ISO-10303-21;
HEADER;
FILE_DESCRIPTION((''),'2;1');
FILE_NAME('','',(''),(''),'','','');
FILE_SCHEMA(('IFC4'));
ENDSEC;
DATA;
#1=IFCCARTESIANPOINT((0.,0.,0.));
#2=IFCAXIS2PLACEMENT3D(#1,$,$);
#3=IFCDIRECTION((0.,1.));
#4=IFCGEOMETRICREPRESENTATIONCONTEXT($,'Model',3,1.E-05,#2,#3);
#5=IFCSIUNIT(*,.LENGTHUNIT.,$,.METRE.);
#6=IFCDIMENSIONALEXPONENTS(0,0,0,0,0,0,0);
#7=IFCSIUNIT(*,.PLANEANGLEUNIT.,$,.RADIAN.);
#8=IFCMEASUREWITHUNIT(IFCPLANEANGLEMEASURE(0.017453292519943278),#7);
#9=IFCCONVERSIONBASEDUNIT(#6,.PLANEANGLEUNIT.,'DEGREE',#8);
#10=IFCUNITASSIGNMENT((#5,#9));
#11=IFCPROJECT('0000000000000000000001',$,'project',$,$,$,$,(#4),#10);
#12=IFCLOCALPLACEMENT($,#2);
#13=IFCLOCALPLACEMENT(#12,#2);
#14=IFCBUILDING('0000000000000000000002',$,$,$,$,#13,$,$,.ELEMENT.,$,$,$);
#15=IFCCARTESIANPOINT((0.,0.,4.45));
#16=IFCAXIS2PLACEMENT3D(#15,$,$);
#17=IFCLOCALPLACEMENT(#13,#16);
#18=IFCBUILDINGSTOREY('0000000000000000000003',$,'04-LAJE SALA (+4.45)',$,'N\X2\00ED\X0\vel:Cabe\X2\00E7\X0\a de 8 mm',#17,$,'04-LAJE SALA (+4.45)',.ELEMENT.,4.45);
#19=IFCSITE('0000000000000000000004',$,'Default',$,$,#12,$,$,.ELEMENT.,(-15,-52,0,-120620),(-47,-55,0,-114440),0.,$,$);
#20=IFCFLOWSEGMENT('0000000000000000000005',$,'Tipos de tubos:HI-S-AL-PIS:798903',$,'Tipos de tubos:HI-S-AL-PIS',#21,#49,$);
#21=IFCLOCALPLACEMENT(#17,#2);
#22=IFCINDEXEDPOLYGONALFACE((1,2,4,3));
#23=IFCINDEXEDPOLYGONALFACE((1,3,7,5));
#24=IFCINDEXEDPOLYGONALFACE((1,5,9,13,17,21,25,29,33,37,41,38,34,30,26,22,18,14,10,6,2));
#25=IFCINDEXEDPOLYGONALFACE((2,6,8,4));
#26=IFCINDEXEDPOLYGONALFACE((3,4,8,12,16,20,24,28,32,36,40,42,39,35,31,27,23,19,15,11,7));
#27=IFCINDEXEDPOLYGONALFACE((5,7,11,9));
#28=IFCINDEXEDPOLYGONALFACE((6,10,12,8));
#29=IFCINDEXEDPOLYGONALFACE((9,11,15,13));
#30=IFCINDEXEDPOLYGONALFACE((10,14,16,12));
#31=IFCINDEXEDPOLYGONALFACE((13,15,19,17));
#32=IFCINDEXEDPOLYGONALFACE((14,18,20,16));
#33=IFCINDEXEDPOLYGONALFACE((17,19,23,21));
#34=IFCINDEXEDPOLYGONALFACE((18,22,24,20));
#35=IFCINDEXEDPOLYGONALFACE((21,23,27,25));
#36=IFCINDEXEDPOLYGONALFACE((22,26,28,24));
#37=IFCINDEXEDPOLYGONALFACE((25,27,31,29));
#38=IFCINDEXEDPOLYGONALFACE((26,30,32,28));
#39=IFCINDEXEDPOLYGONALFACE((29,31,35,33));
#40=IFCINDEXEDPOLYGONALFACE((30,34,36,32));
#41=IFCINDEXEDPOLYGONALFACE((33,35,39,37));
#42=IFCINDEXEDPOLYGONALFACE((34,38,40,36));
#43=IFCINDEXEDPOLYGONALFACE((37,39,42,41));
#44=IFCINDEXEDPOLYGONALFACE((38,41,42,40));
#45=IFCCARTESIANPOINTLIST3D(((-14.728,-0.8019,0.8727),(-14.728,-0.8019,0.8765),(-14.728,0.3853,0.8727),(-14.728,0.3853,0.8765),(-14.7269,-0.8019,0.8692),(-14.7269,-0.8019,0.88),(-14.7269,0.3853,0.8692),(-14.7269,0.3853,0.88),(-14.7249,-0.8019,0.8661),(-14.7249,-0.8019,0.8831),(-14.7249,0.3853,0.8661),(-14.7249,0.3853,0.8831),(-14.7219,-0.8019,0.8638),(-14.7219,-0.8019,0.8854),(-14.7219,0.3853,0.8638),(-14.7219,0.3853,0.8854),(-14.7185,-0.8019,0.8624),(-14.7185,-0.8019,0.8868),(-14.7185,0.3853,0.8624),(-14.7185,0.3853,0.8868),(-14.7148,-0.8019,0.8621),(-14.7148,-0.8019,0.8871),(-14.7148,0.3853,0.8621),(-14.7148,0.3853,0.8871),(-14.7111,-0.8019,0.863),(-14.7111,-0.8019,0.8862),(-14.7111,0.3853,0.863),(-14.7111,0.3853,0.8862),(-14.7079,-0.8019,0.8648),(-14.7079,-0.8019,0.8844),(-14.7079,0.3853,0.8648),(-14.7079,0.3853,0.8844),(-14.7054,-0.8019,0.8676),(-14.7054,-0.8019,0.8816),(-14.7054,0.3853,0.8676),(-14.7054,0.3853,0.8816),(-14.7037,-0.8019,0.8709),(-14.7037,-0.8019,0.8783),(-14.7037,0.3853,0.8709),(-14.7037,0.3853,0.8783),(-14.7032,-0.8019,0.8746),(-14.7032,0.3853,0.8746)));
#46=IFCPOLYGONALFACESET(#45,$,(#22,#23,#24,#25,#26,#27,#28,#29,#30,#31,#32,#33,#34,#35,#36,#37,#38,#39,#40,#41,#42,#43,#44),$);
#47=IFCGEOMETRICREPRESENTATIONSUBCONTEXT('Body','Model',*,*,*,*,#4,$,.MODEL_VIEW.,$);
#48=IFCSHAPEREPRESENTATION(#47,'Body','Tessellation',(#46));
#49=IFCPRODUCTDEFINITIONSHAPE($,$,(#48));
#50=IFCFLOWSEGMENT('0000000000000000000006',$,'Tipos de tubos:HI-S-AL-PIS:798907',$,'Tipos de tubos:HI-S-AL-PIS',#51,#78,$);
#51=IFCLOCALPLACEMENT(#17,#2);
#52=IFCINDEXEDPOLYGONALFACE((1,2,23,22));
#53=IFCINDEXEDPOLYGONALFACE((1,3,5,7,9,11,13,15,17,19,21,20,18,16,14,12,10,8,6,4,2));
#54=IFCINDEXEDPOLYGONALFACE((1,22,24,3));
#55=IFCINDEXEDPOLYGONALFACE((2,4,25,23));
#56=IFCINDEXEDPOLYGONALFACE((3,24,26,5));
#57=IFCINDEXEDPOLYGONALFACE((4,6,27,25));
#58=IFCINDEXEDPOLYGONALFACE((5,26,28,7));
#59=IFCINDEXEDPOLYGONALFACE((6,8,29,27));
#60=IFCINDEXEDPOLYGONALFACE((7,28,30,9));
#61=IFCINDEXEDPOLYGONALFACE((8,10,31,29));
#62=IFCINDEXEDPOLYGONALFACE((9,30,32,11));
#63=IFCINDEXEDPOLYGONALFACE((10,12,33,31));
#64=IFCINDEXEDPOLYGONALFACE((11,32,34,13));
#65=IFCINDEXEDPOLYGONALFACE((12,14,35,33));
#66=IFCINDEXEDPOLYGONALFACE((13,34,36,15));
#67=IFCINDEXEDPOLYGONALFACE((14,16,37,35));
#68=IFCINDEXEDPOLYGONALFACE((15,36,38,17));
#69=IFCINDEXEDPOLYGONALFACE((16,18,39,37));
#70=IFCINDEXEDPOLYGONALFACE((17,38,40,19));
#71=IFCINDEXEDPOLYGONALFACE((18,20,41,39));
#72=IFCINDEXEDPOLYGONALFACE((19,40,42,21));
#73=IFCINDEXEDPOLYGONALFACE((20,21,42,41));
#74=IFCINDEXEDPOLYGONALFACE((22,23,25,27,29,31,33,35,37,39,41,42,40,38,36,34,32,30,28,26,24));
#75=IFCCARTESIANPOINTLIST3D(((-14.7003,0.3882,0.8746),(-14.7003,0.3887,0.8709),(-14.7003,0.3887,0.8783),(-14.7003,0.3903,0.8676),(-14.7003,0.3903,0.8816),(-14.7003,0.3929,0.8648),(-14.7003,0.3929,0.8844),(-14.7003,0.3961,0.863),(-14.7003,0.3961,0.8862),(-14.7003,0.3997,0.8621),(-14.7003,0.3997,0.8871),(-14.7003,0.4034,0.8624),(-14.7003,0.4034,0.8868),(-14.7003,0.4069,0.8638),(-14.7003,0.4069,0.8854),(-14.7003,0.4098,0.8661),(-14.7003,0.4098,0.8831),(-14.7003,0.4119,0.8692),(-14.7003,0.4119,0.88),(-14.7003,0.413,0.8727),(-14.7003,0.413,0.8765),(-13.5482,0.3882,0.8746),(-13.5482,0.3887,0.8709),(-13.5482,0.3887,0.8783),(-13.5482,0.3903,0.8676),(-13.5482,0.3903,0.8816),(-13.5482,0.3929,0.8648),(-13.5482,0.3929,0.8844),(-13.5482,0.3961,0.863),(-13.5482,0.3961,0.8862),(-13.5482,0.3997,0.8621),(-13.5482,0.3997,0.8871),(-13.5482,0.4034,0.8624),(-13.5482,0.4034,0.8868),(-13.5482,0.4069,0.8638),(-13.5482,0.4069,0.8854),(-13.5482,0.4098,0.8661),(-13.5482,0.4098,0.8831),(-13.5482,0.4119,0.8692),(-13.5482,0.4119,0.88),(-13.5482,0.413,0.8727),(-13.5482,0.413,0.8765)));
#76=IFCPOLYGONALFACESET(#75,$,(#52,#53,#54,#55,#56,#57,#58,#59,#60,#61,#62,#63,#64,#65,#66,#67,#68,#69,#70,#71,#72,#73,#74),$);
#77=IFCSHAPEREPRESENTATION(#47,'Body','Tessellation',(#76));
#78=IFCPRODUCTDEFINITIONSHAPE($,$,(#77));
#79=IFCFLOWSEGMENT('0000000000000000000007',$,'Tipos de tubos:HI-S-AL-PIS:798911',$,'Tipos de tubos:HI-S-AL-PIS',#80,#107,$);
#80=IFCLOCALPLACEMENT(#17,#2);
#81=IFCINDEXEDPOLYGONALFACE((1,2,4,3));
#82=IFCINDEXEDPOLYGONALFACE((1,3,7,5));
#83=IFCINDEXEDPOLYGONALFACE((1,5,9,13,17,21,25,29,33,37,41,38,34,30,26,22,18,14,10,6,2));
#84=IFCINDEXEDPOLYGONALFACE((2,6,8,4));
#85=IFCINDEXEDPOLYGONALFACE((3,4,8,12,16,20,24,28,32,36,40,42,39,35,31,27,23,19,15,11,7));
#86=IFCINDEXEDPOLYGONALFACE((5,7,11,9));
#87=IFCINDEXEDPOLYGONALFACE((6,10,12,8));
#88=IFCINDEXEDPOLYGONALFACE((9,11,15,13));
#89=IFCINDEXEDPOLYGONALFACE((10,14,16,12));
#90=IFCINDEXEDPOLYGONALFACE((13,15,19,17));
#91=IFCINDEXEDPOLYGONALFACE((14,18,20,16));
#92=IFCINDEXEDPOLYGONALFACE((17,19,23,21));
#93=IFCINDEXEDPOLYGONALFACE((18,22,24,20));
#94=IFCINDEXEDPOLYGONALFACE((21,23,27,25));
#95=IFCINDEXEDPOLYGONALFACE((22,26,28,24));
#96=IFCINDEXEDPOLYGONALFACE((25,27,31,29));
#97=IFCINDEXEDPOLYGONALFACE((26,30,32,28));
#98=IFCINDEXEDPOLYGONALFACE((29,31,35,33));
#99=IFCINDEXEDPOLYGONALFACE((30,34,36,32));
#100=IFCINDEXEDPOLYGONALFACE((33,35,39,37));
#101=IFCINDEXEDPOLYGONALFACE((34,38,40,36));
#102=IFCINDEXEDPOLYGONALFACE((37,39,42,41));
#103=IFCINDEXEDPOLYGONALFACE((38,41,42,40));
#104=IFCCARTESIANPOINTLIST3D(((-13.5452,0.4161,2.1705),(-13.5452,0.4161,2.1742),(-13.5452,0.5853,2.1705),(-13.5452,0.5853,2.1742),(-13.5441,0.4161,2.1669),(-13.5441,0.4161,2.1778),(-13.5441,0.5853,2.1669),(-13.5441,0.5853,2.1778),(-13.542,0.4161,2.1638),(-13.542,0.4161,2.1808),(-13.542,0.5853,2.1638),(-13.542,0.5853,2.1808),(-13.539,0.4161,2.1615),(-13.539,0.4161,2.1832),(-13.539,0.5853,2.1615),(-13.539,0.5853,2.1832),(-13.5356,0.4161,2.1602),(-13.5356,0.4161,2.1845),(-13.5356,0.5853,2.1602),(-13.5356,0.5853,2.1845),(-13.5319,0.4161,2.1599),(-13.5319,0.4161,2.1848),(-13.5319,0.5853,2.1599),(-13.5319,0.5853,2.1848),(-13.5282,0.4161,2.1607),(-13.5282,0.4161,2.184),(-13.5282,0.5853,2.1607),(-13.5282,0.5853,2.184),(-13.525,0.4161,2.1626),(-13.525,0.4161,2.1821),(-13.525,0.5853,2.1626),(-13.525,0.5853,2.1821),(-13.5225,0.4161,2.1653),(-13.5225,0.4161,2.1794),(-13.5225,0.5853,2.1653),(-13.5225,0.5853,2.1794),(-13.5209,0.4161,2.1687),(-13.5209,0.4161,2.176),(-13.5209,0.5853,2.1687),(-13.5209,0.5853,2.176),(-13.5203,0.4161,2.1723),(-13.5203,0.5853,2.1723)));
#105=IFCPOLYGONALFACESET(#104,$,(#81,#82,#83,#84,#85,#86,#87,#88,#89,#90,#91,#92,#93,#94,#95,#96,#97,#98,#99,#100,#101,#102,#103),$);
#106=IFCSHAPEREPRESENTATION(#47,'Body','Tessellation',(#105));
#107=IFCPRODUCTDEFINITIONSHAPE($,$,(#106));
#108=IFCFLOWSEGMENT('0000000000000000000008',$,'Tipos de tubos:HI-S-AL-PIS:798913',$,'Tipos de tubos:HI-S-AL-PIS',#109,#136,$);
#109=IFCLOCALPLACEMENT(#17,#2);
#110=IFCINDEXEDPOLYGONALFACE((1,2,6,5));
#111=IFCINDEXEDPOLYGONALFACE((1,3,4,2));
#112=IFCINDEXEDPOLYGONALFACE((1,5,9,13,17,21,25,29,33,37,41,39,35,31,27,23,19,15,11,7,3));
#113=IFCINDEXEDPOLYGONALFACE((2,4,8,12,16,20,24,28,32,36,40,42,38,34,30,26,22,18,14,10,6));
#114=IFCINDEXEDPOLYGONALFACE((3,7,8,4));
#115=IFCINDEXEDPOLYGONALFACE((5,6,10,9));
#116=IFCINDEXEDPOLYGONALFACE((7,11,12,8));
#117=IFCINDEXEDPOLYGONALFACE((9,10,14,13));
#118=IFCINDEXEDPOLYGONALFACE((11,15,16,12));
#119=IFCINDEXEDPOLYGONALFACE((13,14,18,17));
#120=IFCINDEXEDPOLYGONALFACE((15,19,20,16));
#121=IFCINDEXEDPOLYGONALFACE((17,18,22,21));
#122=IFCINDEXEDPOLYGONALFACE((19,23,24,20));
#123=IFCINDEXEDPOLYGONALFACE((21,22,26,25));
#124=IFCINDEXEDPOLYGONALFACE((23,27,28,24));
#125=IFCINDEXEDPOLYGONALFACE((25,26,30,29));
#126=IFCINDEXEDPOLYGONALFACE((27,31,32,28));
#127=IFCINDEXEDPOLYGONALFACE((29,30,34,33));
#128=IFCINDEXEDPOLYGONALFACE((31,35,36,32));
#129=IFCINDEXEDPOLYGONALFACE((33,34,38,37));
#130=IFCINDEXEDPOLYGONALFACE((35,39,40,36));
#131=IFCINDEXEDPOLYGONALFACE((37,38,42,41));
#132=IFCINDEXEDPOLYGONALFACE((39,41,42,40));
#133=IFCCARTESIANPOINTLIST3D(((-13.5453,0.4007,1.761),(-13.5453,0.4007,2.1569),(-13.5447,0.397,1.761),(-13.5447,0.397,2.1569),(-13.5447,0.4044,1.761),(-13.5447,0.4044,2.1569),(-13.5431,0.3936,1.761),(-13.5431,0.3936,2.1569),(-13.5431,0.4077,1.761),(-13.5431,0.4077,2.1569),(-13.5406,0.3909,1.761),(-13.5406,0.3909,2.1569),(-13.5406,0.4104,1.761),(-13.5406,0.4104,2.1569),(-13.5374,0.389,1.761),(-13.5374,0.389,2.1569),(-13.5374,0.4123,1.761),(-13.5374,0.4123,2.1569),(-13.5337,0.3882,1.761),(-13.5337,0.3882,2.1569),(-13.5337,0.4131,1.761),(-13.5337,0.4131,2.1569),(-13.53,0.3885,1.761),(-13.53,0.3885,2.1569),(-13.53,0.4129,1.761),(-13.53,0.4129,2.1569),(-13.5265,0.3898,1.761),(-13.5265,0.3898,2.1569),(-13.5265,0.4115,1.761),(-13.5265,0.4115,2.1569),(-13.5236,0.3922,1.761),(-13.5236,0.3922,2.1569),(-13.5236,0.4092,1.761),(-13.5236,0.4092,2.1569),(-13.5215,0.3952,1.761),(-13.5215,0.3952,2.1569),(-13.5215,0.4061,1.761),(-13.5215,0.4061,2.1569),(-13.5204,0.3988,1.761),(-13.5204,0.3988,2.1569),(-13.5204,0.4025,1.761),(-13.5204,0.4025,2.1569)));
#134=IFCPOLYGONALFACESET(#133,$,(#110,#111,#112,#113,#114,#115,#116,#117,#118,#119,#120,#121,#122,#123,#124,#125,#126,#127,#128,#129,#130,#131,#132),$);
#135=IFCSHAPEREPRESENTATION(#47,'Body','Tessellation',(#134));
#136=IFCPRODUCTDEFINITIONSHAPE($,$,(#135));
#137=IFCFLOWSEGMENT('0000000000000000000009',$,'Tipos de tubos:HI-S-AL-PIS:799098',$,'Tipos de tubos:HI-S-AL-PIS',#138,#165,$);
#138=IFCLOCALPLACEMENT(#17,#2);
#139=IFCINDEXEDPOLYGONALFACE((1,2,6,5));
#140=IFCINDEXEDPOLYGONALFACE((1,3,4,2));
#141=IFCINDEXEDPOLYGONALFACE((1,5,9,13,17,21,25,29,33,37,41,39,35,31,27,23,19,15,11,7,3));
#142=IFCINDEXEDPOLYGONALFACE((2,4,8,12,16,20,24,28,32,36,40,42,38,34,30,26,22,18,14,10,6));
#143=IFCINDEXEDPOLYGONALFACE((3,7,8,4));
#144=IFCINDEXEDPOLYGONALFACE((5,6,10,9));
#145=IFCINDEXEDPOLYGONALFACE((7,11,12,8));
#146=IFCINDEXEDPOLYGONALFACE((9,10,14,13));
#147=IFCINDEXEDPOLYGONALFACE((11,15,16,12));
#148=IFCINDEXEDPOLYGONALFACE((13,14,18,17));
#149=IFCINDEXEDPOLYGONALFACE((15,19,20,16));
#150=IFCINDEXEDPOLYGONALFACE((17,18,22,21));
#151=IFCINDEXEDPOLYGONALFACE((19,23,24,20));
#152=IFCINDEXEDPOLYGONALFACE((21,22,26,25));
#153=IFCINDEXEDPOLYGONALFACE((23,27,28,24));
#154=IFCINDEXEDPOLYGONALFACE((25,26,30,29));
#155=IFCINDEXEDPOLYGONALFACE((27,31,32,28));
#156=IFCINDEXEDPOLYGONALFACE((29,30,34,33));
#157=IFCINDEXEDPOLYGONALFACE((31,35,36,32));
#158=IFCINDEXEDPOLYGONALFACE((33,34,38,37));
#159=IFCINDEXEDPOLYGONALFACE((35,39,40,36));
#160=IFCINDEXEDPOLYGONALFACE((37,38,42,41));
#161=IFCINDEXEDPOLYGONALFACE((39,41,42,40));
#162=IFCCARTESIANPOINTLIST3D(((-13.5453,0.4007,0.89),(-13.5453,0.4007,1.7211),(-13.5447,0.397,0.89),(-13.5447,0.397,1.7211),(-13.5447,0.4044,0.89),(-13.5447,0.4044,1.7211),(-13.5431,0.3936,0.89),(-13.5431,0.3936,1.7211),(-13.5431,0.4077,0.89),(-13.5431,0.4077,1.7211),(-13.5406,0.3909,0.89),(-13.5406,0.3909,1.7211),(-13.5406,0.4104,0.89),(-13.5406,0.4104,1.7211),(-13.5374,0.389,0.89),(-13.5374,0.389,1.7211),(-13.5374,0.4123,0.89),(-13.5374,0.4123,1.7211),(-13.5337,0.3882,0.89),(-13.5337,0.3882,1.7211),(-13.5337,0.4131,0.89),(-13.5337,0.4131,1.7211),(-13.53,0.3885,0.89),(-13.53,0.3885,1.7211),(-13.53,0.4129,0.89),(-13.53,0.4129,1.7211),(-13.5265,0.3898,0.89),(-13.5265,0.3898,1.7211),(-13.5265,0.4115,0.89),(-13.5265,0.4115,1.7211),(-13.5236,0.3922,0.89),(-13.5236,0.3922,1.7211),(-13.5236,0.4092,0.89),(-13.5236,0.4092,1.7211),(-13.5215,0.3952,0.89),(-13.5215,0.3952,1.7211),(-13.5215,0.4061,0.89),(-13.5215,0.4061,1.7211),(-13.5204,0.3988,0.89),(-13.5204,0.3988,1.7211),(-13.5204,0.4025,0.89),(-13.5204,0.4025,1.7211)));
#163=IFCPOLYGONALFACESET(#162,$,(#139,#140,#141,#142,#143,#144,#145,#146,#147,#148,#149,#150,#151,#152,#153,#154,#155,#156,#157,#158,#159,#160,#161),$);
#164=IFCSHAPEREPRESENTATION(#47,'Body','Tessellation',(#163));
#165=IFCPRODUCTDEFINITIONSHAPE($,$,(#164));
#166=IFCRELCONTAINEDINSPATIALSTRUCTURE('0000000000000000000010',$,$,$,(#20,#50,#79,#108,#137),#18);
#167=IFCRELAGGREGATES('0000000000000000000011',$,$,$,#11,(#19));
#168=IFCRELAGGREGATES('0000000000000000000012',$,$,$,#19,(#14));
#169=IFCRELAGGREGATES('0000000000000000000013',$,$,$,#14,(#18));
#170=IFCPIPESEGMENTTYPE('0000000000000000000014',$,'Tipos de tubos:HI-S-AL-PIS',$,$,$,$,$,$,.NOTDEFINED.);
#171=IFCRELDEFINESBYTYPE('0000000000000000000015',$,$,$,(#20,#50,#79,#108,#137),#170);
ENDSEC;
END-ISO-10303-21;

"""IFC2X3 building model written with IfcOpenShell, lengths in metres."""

from ifc_helpers import new_model, entity, si_unit, converted_unit, direction, frame, frame_2d, origin, origin_2d_with_axis, place, context, subcontext, project, spatial, circle, extrude, type_object, element, save


model = new_model("IFC2X3")

# Units and contexts
model_context = context("Model", 3, precision=1e-05, world=origin(), true_north=direction((0.0, 1.0)))
body_context = subcontext(model_context, "Body", "Model", "MODEL_VIEW")
ifc_project = project(units=[si_unit("LENGTHUNIT", "METRE"), converted_unit("PLANEANGLEUNIT", "DEGREE", entity("IfcPlaneAngleMeasure", 0.017453292519943278), si_unit("PLANEANGLEUNIT", "RADIAN"), dimensions=[0, 0, 0, 0, 0, 0, 0])], contexts=[model_context])

# Site, building, storey
site_placement = place(None, origin())
site = spatial("IfcSite", under=ifc_project, at=site_placement, Name="Default", CompositionType="ELEMENT", RefLatitude=(-15, -52, 0, -120620), RefLongitude=(-47, -55, 0, -114440), RefElevation=0.0)
building_placement = place(site_placement, origin())
building = spatial("IfcBuilding", under=site, at=building_placement, CompositionType="ELEMENT")
storey_placement = place(building_placement, frame((0.0, 0.0, 4.45)))
storey = spatial("IfcBuildingStorey", under=building, at=storey_placement, Name="04-LAJE SALA (+4.45)", ObjectType="Nível:Cabeça de 8 mm", LongName="04-LAJE SALA (+4.45)", CompositionType="ELEMENT", Elevation=4.45)

# Flow segments
pipe_segment_type_1 = type_object("IfcPipeSegmentType", Name="Tipos de tubos:HI-S-AL-PIS", PredefinedType="NOTDEFINED")
flow_segment_1_placement = place(storey_placement, origin())
element("IfcFlowSegment", 1, at=flow_segment_1_placement, inside=storey, type_object=pipe_segment_type_1, Name="Tipos de tubos:HI-S-AL-PIS:798903", ObjectType="Tipos de tubos:HI-S-AL-PIS", context=body_context, shape_type="SweptSolid", body=[
    extrude(circle(Radius=0.0125, at=origin_2d_with_axis()), frame((-14.7157, -0.8019, 0.8746), z_axis=(0.0, 1.0, 0.0), x_axis=(1.0, 0.0, 0.0)), (0.0, 0.0, 1.0), 1.1872),
])
flow_segment_2_placement = place(storey_placement, origin())
element("IfcFlowSegment", 2, at=flow_segment_2_placement, inside=storey, type_object=pipe_segment_type_1, Name="Tipos de tubos:HI-S-AL-PIS:798907", ObjectType="Tipos de tubos:HI-S-AL-PIS", context=body_context, shape_type="SweptSolid", body=[
    extrude(circle(Radius=0.0125, at=frame_2d((0.0, 0.0), x_axis=(1.0, 0.0))), frame((-14.7003, 0.4007, 0.8746), z_axis=(1.0, 0.0, 0.0), x_axis=(0.0, -1.0, 0.0)), (0.0, 0.0, 1.0), 1.1521),
])
flow_segment_3_placement = place(storey_placement, origin())
element("IfcFlowSegment", 3, at=flow_segment_3_placement, inside=storey, type_object=pipe_segment_type_1, Name="Tipos de tubos:HI-S-AL-PIS:798911", ObjectType="Tipos de tubos:HI-S-AL-PIS", context=body_context, shape_type="SweptSolid", body=[
    extrude(circle(Radius=0.0125, at=origin_2d_with_axis()), frame((-13.5328, 0.4161, 2.1723), z_axis=(0.0, 1.0, 0.0), x_axis=(1.0, 0.0, 0.0)), (0.0, 0.0, 1.0), 0.1692),
])
flow_segment_4_placement = place(storey_placement, origin())
element("IfcFlowSegment", 4, at=flow_segment_4_placement, inside=storey, type_object=pipe_segment_type_1, Name="Tipos de tubos:HI-S-AL-PIS:798913", ObjectType="Tipos de tubos:HI-S-AL-PIS", context=body_context, shape_type="SweptSolid", body=[
    extrude(circle(Radius=0.0125, at=origin_2d_with_axis()), frame((-13.5328, 0.4007, 1.761), z_axis=(0.0, 0.0, 1.0), x_axis=(-1.0, 0.0, 0.0)), (0.0, 0.0, 1.0), 0.3959),
])
flow_segment_5_placement = place(storey_placement, origin())
element("IfcFlowSegment", 5, at=flow_segment_5_placement, inside=storey, type_object=pipe_segment_type_1, Name="Tipos de tubos:HI-S-AL-PIS:799098", ObjectType="Tipos de tubos:HI-S-AL-PIS", context=body_context, shape_type="SweptSolid", body=[
    extrude(circle(Radius=0.0125, at=origin_2d_with_axis()), frame((-13.5328, 0.4007, 0.89), z_axis=(0.0, 0.0, 1.0), x_axis=(-1.0, 0.0, 0.0)), (0.0, 0.0, 1.0), 0.8311),
])

save(model, "model.ifc")
